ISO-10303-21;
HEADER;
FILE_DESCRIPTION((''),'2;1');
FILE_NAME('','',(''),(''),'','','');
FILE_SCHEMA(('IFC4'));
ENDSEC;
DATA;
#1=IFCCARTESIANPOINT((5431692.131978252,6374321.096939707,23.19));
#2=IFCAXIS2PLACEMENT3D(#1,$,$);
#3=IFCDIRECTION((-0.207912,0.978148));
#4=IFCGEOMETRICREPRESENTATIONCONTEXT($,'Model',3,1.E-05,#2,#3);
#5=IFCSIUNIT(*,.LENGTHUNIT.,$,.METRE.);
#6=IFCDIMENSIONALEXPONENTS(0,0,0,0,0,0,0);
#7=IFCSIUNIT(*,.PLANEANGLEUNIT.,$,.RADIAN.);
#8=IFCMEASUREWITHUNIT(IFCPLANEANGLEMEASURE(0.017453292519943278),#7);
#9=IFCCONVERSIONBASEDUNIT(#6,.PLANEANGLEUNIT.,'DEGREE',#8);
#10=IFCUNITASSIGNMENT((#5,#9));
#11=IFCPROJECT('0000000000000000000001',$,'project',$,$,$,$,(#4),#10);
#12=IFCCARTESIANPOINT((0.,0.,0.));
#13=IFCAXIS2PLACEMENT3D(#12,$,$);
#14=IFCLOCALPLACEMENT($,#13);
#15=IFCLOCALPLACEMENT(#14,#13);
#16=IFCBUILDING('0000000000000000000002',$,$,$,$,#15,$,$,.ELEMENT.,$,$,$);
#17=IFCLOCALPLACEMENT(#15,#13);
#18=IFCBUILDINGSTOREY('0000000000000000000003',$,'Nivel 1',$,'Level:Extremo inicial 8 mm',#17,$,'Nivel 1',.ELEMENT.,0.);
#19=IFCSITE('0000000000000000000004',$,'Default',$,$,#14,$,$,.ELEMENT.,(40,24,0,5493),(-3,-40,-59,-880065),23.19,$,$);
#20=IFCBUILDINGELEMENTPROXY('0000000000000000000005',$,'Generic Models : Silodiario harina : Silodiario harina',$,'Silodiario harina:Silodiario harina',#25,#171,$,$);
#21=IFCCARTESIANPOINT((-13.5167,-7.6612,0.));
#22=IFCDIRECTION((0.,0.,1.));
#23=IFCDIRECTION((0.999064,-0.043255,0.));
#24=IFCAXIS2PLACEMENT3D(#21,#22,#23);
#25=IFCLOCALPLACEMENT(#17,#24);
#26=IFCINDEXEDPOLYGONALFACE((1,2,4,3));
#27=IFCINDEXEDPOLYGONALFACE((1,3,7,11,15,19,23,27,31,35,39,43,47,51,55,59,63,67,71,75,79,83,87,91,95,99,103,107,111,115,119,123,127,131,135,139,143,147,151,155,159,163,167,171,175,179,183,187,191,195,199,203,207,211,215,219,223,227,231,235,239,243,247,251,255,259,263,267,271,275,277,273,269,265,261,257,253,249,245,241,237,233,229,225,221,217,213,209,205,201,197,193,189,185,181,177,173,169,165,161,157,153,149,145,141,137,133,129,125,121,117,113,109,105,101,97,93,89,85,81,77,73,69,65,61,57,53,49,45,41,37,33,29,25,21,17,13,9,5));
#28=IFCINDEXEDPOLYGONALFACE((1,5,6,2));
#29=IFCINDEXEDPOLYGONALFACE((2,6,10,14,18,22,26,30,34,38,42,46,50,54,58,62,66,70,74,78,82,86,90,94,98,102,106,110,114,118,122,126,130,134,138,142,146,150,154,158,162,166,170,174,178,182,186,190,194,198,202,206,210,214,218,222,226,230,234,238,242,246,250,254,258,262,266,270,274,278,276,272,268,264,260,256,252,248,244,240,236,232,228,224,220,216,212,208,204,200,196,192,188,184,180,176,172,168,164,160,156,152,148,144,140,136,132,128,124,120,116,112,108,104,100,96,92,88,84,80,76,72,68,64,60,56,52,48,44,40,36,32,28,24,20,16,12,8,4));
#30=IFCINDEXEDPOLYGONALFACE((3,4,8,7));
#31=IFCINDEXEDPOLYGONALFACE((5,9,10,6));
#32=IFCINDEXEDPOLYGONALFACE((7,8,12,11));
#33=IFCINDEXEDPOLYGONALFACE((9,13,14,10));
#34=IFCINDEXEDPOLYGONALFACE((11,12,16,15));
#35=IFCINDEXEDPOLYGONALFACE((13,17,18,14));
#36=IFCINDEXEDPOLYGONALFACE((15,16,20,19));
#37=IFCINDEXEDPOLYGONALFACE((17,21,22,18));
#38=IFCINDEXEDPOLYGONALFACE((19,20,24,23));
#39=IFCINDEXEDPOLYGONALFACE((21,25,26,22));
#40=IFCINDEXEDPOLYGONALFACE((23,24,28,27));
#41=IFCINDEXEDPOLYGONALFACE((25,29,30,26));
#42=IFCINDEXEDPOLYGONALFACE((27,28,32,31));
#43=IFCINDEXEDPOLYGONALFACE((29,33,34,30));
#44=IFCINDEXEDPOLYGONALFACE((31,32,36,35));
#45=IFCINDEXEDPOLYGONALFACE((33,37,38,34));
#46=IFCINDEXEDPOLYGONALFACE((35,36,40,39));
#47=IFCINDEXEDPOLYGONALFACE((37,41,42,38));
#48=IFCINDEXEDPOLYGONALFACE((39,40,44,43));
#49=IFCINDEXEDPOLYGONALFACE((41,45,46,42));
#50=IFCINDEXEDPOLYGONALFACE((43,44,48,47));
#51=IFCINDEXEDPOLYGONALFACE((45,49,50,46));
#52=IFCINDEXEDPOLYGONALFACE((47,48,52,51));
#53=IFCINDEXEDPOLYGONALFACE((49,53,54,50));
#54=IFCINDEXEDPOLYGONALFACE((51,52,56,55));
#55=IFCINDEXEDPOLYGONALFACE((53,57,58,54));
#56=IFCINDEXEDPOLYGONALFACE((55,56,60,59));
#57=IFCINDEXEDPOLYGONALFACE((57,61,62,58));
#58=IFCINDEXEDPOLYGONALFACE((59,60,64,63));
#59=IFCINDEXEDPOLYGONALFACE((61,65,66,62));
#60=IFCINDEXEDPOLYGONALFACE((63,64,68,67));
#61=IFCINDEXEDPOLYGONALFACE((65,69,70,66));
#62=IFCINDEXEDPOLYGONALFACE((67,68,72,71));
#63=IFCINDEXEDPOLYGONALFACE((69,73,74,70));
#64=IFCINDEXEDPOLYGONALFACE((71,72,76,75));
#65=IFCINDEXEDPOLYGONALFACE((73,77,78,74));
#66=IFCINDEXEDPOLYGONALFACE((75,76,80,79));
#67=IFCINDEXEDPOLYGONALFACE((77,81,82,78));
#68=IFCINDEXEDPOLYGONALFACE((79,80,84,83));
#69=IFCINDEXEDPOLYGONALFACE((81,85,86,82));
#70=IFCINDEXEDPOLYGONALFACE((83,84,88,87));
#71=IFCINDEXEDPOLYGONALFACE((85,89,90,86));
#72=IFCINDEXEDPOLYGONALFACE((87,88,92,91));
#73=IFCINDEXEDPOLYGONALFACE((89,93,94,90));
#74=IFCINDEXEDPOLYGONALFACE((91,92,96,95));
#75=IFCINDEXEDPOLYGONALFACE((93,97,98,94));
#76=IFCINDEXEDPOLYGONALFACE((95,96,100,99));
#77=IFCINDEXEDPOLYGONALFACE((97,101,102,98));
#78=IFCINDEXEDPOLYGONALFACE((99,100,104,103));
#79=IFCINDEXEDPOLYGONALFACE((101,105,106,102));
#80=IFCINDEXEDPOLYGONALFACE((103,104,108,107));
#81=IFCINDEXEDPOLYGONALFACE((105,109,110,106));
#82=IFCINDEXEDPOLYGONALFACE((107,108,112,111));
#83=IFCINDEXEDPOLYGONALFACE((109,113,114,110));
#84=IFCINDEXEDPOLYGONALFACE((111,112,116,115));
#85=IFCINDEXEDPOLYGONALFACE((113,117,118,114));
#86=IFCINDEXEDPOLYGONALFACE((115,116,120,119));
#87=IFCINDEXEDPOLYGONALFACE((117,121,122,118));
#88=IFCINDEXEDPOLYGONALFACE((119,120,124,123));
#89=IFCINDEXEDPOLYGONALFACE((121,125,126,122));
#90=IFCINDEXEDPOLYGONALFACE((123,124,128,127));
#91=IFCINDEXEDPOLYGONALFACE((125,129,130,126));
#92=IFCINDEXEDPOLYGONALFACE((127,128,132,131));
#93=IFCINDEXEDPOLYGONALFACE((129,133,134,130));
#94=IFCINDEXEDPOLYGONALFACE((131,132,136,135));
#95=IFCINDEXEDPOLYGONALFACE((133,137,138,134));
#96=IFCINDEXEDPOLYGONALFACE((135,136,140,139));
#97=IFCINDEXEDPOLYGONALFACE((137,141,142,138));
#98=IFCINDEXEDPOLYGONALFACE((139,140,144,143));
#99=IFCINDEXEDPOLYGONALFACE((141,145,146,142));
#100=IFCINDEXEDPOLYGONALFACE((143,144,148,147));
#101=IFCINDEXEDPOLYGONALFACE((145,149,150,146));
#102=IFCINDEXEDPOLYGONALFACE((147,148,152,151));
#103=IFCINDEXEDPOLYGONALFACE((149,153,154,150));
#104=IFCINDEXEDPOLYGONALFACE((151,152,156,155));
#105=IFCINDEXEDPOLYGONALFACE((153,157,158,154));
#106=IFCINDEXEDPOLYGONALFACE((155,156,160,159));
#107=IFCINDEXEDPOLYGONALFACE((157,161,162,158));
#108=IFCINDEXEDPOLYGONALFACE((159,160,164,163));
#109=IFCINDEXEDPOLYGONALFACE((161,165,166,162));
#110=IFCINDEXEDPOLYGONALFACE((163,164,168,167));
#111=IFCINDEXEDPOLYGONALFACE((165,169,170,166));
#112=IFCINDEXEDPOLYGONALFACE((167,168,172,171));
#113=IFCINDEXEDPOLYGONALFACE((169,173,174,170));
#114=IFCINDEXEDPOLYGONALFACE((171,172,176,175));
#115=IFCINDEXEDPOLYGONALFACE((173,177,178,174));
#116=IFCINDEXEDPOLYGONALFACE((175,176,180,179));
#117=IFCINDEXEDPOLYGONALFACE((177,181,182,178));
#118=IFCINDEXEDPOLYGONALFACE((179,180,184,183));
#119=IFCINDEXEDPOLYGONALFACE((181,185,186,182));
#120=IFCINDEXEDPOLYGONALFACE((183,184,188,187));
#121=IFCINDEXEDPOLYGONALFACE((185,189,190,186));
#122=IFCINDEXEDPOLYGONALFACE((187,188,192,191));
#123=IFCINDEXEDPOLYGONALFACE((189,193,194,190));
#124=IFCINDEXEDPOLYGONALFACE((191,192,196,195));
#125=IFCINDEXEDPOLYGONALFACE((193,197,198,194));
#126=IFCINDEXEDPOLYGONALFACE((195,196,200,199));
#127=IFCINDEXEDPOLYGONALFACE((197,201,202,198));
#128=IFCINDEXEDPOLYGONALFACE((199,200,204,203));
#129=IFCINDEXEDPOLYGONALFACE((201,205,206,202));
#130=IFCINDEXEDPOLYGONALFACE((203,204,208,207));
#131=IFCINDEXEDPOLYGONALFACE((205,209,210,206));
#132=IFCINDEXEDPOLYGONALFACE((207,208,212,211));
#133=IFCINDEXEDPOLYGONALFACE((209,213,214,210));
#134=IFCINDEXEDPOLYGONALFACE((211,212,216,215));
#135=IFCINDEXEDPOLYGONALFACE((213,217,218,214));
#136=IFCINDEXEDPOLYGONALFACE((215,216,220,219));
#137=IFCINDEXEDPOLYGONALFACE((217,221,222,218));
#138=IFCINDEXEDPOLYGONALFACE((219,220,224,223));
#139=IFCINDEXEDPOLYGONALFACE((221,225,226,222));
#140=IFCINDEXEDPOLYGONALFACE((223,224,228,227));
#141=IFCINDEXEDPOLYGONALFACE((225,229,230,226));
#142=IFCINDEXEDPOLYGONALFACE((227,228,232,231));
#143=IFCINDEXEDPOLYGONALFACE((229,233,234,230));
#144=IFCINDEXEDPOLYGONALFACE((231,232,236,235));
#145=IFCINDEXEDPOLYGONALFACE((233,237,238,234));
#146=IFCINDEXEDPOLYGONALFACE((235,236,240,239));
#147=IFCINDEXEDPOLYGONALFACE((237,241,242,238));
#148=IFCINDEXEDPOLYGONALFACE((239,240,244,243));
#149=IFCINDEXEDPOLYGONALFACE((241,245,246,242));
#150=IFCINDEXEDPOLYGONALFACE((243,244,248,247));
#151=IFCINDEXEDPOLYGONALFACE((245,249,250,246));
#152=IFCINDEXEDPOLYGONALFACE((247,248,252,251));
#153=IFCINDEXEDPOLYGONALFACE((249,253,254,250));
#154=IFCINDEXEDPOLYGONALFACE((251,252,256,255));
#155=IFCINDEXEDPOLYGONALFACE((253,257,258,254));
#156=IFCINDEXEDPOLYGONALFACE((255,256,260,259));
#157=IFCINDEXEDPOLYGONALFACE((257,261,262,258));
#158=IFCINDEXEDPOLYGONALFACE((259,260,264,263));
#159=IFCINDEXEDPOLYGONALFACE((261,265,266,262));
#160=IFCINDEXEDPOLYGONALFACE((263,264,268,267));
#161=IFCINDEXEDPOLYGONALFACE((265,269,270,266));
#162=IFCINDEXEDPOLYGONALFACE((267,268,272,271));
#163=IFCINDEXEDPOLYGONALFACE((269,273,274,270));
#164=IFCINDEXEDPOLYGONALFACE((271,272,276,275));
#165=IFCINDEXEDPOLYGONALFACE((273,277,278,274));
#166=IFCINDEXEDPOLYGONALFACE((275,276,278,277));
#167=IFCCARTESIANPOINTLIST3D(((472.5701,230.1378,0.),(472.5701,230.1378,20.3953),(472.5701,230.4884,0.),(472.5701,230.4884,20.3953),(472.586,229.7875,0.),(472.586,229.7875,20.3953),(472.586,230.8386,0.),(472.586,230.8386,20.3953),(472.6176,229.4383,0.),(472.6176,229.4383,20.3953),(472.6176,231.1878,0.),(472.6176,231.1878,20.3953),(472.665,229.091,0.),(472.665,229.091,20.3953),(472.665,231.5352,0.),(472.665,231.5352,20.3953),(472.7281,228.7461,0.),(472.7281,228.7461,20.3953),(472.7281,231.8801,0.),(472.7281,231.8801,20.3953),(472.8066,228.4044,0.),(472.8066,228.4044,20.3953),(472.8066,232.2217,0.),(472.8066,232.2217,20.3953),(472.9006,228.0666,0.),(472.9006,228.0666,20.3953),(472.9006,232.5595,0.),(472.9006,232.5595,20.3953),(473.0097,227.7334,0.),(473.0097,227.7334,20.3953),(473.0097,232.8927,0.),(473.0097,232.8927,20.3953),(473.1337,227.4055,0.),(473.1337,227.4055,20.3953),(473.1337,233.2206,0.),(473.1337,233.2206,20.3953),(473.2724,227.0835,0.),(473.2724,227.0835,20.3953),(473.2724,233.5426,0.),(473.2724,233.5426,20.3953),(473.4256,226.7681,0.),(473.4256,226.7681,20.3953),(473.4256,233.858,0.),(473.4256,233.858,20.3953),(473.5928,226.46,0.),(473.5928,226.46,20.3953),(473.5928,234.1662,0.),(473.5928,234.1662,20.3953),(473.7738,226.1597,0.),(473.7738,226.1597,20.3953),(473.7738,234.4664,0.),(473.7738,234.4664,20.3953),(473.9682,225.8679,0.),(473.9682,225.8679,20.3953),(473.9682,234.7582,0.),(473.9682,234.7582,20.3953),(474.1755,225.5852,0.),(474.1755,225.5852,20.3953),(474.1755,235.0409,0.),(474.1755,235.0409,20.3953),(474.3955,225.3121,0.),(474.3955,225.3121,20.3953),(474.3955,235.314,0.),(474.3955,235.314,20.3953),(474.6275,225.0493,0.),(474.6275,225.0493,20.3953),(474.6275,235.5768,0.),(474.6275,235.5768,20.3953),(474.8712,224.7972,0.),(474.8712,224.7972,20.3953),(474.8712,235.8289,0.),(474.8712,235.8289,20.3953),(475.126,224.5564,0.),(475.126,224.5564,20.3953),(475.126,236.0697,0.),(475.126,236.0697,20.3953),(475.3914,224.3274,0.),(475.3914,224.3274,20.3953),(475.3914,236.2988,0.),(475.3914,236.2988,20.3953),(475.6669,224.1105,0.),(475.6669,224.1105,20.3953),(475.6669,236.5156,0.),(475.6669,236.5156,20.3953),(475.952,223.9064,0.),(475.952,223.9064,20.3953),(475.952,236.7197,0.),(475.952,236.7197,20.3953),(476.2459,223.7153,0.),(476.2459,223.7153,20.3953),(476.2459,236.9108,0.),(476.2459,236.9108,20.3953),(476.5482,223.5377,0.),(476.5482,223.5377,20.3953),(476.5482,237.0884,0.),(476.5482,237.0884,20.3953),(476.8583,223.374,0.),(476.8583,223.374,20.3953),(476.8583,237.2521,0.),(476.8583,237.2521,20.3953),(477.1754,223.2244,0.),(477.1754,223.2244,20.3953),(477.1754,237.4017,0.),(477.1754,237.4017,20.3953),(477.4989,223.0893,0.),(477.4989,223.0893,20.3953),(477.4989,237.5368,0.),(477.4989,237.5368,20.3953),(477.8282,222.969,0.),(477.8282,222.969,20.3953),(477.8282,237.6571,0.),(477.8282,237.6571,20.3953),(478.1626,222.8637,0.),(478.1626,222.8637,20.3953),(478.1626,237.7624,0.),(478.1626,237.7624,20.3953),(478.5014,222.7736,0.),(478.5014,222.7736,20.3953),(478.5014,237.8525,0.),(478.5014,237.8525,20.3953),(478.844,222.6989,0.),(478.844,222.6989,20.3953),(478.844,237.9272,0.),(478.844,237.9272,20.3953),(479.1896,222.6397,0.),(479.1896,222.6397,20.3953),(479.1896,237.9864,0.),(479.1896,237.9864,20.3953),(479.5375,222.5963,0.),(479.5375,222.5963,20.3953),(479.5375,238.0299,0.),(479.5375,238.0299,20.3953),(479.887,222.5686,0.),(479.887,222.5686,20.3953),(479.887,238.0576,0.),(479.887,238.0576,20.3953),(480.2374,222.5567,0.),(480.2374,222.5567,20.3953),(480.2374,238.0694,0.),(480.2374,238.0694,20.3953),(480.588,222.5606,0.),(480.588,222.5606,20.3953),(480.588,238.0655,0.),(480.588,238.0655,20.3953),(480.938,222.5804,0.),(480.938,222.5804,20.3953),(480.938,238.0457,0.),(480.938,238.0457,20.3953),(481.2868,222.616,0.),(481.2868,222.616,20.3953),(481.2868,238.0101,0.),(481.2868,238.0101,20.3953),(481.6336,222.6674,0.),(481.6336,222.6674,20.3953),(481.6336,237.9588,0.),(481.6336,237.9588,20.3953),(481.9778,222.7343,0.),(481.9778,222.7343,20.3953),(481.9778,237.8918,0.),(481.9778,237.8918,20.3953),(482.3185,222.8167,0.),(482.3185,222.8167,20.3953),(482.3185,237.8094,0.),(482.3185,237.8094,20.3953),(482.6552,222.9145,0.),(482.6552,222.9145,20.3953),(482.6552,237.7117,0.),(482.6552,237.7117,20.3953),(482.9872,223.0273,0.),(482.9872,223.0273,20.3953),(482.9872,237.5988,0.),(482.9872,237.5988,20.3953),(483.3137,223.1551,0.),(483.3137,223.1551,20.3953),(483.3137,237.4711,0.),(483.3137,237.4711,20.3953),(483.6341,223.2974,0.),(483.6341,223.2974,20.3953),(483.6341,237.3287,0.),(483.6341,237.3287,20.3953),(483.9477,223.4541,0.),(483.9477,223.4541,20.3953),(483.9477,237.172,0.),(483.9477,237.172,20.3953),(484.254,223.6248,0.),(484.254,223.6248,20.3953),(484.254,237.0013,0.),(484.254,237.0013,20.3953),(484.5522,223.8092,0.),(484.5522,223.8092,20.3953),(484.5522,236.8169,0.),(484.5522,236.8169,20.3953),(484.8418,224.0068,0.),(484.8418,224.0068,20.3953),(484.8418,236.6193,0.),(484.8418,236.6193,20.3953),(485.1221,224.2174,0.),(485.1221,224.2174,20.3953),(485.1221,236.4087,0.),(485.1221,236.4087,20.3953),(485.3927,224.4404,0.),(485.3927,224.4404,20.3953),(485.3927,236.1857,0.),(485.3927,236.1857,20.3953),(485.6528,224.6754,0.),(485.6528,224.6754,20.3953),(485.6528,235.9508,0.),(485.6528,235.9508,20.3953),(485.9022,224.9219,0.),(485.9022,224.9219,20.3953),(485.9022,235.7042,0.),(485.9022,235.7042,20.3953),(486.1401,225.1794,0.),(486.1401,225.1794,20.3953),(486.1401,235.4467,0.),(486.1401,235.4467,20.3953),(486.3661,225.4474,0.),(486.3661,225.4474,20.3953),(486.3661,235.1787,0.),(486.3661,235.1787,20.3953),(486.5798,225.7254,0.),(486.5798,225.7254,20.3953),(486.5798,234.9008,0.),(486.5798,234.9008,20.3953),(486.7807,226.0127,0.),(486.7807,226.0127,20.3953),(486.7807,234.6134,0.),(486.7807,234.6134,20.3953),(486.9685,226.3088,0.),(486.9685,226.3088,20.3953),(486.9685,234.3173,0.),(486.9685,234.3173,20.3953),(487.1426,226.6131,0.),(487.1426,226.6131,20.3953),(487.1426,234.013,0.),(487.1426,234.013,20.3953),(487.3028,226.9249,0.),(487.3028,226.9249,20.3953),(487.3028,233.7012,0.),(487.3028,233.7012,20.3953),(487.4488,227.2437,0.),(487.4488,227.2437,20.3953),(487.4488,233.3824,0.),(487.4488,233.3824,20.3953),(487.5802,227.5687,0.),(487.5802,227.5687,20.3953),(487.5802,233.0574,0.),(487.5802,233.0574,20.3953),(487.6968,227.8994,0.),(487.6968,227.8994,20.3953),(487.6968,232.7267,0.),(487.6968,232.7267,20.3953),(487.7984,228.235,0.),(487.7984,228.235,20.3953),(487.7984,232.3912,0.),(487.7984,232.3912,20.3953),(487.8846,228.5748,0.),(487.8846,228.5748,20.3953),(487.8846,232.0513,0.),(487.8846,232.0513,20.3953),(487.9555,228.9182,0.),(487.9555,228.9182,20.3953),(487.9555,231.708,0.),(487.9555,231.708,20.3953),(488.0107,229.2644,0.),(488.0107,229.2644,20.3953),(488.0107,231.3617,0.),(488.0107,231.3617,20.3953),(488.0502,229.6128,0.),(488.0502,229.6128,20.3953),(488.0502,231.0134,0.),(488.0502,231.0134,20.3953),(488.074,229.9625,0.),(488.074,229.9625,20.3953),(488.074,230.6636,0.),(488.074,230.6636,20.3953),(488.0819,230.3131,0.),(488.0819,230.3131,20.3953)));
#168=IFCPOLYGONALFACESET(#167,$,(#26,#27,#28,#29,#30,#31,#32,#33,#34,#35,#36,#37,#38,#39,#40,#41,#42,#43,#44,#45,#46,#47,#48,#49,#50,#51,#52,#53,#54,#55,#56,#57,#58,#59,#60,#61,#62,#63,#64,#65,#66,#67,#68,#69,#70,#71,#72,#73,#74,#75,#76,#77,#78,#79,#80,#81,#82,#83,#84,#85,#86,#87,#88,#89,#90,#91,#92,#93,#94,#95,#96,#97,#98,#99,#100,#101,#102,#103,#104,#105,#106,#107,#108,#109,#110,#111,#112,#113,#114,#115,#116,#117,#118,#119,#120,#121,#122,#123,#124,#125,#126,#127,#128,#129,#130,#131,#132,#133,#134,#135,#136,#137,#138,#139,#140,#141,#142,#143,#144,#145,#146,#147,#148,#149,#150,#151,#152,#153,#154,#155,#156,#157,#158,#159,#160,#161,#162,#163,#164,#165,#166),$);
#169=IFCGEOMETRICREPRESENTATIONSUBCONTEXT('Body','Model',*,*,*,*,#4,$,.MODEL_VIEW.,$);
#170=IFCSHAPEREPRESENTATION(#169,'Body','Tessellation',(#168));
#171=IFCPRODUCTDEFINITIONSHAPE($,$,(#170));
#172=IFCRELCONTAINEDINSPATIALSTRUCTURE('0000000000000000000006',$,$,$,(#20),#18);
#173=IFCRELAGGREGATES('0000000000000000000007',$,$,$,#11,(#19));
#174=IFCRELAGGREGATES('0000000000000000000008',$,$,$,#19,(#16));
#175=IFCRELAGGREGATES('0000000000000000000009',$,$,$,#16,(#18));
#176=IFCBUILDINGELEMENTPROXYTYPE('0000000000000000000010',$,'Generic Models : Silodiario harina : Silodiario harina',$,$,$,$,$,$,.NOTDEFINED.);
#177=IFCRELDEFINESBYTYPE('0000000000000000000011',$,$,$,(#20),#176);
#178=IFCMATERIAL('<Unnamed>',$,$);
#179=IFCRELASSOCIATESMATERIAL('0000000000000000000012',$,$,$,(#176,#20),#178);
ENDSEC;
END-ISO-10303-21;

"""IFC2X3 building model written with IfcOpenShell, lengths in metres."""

from ifc_helpers import new_model, entity, si_unit, converted_unit, direction, frame, origin, origin_2d_with_axis, place, context, subcontext, project, spatial, circle, extrude, source, transform, mapped, material, type_object, type_shapes, element, save


model = new_model("IFC2X3")

# Units and contexts
model_context = context("Model", 3, precision=1e-05, world=frame((5431692.131978252, 6374321.096939707, 23.19)), true_north=direction((-0.207912, 0.978148)))
body_context = subcontext(model_context, "Body", "Model", "MODEL_VIEW")
ifc_project = project(units=[si_unit("LENGTHUNIT", "METRE"), converted_unit("PLANEANGLEUNIT", "DEGREE", entity("IfcPlaneAngleMeasure", 0.017453292519943278), si_unit("PLANEANGLEUNIT", "RADIAN"), dimensions=[0, 0, 0, 0, 0, 0, 0])], contexts=[model_context])

# Site, building, storey
site_placement = place(None, origin())
site = spatial("IfcSite", under=ifc_project, at=site_placement, Name="Default", CompositionType="ELEMENT", RefLatitude=(40, 24, 0, 5493), RefLongitude=(-3, -40, -59, -880065), RefElevation=23.19)
building_placement = place(site_placement, origin())
building = spatial("IfcBuilding", under=site, at=building_placement, CompositionType="ELEMENT")
storey_placement = place(building_placement, origin())
storey = spatial("IfcBuildingStorey", under=building, at=storey_placement, Name="Nivel 1", ObjectType="Level:Extremo inicial 8 mm", LongName="Nivel 1", CompositionType="ELEMENT", Elevation=0.0)

# Building element proxy
ifc_material_1 = material(Name="<Unnamed>")
building_element_proxy_type_1 = type_object("IfcBuildingElementProxyType", Name="Generic Models : Silodiario harina : Silodiario harina", PredefinedType="NOTDEFINED", material=ifc_material_1)
shared_shape_1 = source(origin(), body_context, "Body", "SweptSolid", [
    extrude(circle(Radius=7.7569, at=origin_2d_with_axis()), frame((480.325, 230.3131, 0.0)), (0.0, 0.0, 1.0), 20.3953),
])
type_shapes(building_element_proxy_type_1, [shared_shape_1])
proxy_1_placement = place(storey_placement, frame((-13.5167, -7.6612, 0.0), z_axis=(0.0, 0.0, 1.0), x_axis=(0.999064, -0.043255, 0.0)))
element("IfcBuildingElementProxy", 1, at=proxy_1_placement, inside=storey, type_object=building_element_proxy_type_1, material=ifc_material_1, Name="Generic Models : Silodiario harina : Silodiario harina", ObjectType="Silodiario harina:Silodiario harina", context=body_context, shape_type="MappedRepresentation", body=[
    mapped(shared_shape_1, transform((0.0, 0.0, 0.0), scale=1.0)),
])

save(model, "model.ifc")
